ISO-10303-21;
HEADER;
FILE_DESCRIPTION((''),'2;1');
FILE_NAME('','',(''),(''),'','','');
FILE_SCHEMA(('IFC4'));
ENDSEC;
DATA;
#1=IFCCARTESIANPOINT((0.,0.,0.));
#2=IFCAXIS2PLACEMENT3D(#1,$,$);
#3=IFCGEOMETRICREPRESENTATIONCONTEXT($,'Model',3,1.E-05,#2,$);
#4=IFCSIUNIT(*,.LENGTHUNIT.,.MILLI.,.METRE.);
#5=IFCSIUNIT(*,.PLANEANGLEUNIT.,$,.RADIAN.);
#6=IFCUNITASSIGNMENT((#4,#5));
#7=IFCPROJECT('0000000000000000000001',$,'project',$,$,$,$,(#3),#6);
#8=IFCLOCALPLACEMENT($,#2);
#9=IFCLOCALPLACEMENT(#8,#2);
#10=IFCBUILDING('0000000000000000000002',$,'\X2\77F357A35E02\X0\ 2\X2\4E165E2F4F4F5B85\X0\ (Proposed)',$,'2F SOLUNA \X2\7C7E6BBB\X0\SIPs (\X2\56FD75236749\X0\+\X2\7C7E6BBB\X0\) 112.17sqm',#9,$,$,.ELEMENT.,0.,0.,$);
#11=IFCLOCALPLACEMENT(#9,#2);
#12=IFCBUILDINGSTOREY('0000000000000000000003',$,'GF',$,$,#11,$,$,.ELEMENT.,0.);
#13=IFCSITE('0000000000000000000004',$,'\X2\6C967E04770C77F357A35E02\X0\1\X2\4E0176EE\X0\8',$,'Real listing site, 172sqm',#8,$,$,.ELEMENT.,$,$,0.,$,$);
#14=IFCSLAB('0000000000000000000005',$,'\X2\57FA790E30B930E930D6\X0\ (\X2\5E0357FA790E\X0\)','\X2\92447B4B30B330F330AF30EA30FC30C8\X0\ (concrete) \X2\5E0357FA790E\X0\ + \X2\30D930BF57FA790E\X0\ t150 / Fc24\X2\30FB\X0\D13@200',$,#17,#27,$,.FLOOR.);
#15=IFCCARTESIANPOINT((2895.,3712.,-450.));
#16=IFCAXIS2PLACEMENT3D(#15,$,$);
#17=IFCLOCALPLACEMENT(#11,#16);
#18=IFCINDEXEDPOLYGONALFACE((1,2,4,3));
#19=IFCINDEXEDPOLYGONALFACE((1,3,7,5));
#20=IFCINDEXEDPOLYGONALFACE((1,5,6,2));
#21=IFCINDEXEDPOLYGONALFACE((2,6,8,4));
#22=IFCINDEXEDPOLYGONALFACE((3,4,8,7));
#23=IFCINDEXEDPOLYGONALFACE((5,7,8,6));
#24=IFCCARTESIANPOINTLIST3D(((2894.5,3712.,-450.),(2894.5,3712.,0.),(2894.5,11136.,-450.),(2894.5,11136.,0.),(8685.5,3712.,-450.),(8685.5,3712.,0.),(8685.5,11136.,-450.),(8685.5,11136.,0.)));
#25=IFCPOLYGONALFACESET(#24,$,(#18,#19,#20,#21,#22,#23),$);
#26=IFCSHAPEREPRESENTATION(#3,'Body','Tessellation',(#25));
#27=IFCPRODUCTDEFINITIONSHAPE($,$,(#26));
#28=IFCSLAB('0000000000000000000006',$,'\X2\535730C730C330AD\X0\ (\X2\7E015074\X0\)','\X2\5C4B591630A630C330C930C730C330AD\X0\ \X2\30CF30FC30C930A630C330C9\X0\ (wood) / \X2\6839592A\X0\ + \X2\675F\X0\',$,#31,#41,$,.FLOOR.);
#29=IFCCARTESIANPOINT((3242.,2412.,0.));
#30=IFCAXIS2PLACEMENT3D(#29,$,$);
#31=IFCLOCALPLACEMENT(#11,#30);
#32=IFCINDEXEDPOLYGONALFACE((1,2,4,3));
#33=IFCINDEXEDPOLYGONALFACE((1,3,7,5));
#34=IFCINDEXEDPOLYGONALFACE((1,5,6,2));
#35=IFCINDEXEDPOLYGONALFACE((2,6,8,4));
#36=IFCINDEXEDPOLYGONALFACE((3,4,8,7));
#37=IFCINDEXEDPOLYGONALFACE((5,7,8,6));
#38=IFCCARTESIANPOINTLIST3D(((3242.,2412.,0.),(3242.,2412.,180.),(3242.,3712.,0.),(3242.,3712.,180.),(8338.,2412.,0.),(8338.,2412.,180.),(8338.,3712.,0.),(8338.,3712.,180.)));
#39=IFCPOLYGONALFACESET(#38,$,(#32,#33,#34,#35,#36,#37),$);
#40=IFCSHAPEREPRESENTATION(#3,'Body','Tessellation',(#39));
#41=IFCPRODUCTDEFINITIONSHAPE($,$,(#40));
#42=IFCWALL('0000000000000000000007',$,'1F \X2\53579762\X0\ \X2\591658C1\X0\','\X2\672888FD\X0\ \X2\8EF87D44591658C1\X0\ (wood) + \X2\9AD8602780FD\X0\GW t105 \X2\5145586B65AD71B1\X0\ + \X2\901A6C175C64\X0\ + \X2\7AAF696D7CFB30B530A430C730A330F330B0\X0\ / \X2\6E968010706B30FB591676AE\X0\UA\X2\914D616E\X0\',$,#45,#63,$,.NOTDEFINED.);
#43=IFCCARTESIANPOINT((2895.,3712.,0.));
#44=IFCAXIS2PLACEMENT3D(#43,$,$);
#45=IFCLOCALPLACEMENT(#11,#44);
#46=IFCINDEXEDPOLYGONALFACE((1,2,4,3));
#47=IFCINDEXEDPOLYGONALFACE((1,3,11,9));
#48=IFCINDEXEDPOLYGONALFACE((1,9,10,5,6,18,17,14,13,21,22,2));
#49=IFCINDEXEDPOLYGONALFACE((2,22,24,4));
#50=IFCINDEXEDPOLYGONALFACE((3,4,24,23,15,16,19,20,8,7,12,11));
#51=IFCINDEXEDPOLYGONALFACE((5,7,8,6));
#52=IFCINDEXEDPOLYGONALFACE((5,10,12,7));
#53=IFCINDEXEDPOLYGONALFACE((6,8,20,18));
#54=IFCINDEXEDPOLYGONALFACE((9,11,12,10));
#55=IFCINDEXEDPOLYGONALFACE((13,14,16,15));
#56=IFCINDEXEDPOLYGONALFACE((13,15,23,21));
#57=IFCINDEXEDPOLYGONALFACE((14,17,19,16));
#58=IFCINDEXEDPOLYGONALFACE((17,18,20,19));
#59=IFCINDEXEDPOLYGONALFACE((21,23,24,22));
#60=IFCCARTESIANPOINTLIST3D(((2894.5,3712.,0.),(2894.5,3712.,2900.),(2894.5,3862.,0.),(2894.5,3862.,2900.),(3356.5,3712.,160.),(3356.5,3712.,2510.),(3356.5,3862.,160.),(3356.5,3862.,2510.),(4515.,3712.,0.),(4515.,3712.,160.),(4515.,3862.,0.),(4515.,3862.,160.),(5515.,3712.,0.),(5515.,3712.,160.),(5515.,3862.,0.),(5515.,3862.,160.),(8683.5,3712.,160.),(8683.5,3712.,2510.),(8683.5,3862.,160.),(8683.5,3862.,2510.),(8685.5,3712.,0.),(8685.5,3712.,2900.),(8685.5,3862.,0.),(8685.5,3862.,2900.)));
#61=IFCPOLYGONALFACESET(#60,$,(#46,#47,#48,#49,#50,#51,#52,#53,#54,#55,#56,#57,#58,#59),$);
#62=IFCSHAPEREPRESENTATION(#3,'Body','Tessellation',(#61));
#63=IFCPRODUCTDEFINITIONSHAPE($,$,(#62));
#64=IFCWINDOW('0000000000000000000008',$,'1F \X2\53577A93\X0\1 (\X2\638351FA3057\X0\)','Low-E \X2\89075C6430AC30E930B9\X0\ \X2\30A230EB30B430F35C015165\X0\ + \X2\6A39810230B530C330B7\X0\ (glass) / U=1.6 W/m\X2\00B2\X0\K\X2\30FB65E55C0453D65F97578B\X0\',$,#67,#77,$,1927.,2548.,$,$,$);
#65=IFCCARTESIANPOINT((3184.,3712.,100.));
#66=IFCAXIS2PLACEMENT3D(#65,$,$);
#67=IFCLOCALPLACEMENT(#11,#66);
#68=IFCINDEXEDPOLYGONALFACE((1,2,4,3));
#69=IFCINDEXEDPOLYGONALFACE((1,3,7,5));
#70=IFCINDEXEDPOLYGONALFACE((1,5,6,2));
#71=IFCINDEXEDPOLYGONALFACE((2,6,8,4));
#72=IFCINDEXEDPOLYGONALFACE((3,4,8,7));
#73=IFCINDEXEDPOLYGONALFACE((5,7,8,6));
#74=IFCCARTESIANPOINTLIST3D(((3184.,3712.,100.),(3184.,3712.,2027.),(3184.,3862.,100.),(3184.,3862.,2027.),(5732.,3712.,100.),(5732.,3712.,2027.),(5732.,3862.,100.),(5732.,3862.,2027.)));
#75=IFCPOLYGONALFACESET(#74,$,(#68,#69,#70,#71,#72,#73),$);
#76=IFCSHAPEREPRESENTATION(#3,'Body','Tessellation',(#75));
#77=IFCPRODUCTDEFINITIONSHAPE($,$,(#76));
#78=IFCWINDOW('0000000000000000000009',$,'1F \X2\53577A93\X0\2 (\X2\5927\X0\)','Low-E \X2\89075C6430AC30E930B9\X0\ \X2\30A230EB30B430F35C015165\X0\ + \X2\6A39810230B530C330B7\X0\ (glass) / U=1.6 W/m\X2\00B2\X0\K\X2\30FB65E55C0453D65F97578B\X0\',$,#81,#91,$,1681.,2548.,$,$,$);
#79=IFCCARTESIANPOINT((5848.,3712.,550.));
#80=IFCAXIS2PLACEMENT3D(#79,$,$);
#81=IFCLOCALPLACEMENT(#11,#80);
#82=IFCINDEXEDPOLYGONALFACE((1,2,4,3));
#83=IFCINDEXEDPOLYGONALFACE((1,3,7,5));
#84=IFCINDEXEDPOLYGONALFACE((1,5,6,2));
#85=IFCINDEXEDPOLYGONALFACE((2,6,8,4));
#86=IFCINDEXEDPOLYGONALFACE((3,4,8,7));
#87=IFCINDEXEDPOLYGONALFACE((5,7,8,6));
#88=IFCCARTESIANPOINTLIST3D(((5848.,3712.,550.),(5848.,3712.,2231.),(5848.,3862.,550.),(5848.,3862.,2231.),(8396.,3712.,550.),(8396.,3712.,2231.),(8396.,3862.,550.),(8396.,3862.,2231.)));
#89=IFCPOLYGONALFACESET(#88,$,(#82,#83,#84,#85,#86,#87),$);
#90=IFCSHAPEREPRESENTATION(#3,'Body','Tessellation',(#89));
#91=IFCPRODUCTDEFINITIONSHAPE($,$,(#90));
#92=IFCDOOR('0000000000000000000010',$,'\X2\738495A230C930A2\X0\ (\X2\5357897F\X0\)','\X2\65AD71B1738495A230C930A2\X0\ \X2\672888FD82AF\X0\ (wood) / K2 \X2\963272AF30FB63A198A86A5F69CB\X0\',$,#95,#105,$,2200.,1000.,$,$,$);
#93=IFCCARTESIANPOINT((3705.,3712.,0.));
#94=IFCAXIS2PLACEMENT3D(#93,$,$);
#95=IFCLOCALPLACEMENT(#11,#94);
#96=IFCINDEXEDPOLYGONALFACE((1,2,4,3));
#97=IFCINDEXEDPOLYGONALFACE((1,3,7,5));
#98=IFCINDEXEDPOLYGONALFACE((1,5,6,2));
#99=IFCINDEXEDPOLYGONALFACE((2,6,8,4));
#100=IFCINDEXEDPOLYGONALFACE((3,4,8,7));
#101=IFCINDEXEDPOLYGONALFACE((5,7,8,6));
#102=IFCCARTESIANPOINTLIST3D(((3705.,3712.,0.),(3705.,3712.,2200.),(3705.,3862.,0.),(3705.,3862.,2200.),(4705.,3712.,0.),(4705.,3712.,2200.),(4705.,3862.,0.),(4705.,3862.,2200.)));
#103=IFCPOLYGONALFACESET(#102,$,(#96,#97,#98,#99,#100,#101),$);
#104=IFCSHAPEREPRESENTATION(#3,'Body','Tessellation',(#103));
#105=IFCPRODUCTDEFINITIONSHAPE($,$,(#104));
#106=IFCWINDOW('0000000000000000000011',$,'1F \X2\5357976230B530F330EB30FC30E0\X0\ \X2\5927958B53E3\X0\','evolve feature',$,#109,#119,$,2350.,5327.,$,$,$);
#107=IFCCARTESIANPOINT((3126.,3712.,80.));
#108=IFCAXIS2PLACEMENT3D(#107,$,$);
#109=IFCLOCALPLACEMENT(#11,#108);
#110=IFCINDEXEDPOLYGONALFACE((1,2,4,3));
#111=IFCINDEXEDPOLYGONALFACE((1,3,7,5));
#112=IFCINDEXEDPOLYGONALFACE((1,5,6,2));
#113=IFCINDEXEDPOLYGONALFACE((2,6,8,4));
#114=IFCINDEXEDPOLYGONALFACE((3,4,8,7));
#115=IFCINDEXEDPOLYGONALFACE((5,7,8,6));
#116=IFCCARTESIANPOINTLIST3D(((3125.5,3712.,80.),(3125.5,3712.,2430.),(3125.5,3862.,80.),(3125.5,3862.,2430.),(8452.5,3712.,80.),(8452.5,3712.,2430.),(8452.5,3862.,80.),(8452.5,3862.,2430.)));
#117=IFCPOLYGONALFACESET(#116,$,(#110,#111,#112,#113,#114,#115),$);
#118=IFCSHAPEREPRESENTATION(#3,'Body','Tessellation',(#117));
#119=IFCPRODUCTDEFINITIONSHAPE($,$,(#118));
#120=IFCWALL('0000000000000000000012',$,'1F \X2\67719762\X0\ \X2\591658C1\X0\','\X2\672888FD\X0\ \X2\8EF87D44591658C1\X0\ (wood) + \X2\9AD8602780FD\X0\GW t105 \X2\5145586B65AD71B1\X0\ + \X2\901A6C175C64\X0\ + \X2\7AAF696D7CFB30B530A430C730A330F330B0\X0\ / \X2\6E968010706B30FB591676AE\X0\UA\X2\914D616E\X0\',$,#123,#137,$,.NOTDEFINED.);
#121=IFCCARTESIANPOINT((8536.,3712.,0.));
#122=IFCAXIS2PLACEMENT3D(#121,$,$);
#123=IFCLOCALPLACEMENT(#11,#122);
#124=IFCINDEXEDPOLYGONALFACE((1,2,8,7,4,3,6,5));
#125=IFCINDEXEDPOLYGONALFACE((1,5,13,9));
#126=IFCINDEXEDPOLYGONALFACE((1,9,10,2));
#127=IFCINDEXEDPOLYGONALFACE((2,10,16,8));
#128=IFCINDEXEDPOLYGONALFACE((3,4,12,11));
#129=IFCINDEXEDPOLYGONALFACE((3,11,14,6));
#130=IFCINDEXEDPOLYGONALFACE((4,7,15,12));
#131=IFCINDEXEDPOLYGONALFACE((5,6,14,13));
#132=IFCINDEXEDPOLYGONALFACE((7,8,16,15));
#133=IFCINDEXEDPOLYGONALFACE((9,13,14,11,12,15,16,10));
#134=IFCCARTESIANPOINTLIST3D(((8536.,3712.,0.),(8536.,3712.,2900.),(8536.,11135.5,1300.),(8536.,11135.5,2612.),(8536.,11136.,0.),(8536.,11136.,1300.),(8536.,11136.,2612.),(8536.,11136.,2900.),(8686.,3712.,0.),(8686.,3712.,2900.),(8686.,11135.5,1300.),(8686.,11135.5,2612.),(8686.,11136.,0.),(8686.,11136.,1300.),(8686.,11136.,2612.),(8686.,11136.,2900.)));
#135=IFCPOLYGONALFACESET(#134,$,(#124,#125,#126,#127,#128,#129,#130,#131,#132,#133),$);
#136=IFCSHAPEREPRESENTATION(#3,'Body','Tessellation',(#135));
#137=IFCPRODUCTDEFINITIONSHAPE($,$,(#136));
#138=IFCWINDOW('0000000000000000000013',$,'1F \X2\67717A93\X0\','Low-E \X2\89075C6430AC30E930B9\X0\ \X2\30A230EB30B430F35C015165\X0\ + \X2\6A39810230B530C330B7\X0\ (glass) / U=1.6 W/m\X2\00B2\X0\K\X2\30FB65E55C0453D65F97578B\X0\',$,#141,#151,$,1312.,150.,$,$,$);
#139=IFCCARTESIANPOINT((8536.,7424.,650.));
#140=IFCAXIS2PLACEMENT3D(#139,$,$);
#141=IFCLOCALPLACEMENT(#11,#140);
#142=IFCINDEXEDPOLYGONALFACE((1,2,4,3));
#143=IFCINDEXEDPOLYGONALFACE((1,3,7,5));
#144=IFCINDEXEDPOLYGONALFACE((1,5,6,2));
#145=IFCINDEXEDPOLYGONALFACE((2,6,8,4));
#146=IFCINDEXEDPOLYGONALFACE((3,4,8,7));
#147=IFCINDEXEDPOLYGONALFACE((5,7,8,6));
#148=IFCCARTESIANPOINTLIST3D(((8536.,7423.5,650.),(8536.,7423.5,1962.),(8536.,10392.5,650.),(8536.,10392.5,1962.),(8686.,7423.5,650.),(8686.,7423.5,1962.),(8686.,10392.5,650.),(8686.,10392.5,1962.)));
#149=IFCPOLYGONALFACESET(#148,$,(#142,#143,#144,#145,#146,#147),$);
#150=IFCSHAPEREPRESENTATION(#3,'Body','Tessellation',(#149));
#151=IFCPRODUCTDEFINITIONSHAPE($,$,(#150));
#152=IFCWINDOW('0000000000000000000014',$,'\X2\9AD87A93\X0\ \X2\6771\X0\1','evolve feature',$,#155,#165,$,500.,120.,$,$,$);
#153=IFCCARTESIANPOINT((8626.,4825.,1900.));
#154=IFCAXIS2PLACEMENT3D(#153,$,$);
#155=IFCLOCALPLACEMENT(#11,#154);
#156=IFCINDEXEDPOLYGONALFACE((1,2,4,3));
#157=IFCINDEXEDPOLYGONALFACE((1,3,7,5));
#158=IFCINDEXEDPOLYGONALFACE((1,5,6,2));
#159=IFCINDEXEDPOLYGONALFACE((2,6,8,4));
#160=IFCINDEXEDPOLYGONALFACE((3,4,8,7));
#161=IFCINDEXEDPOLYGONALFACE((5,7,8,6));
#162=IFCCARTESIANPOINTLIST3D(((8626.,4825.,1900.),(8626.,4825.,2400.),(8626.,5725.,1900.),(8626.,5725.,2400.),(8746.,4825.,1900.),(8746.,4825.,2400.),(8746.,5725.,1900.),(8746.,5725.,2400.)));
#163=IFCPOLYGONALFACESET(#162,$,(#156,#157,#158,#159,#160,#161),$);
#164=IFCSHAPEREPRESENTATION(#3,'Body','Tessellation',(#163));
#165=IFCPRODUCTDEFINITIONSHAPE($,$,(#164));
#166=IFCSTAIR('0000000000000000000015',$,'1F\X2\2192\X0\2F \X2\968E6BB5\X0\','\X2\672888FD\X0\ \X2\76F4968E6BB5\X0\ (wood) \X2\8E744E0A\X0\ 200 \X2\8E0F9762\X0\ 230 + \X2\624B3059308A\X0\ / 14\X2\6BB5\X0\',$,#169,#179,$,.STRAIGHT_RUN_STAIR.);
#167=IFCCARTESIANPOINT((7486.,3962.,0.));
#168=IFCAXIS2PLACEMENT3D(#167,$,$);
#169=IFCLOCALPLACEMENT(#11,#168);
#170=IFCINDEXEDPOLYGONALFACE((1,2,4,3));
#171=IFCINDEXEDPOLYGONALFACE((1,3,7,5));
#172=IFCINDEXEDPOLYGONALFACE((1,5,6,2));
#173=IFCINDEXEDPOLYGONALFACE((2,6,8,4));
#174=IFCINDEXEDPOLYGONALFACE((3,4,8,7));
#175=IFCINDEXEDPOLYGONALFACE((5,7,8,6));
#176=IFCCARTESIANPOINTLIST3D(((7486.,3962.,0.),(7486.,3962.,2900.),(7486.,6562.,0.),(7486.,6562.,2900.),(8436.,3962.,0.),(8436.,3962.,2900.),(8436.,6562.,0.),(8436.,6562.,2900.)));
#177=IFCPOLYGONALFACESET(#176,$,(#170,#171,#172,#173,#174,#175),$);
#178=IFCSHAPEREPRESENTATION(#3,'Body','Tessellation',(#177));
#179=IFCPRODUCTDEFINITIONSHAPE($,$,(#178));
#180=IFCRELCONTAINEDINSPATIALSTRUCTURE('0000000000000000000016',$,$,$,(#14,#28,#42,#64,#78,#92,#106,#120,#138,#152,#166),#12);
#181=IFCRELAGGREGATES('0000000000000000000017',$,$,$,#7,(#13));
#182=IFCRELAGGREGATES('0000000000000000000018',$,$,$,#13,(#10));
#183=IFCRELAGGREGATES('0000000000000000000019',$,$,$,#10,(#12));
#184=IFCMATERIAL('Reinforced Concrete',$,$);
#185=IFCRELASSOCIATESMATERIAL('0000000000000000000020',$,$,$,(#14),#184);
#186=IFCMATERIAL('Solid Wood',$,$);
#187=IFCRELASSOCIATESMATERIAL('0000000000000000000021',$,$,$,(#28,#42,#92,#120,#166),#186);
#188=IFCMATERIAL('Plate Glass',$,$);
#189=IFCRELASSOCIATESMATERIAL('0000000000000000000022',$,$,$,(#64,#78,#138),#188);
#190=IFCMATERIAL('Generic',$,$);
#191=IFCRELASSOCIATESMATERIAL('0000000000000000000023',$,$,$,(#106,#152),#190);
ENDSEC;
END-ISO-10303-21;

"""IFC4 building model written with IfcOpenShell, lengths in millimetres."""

from ifc_helpers import new_model, si_unit, frame, frame_2d, origin, place, context, project, spatial, rectangle, extrude, material, element, fill, save


model = new_model("IFC4")

# Units and contexts
model_context = context("Model", 3, precision=1e-05, world=origin())
ifc_project = project(units=[si_unit("LENGTHUNIT", "METRE", prefix="MILLI"), si_unit("PLANEANGLEUNIT", "RADIAN")], contexts=[model_context])

# Site, building, storey
site_placement = place(None, origin())
site = spatial("IfcSite", under=ifc_project, at=site_placement, Name="沖縄県石垣市1丁目8", ObjectType="Real listing site, 172sqm", CompositionType="ELEMENT", RefElevation=0.0)
building_placement = place(site_placement, origin())
building = spatial("IfcBuilding", under=site, at=building_placement, Name="石垣市 2世帯住宅 (Proposed)", ObjectType="2F SOLUNA 籾殻SIPs (国産杉+籾殻) 112.17sqm", CompositionType="ELEMENT", ElevationOfRefHeight=0.0, ElevationOfTerrain=0.0)
storey_placement = place(building_placement, origin())
storey = spatial("IfcBuildingStorey", under=building, at=storey_placement, Name="GF", CompositionType="ELEMENT", Elevation=0.0)

# Slabs
ifc_material_1 = material(Name="Reinforced Concrete")
slab_1_placement = place(storey_placement, frame((2895.0, 3712.0, -450.0)))
element("IfcSlab", 1, at=slab_1_placement, inside=storey, material=ifc_material_1, Name="基礎スラブ (布基礎)", Description="鉄筋コンクリート (concrete) 布基礎 + ベタ基礎 t150 / Fc24・D13@200", PredefinedType="FLOOR", context=model_context, shape_type="SweptSolid", body=[
    extrude(rectangle(XDim=5791.0, YDim=7424.0, at=frame_2d((2895.0, 3712.0))), frame((2895.0, 3712.0, -450.0)), (0.0, 0.0, 1.0), 450.0),
])
ifc_material_2 = material(Name="Solid Wood")
slab_2_placement = place(storey_placement, frame((3242.0, 2412.0, 0.0)))
element("IfcSlab", 2, at=slab_2_placement, inside=storey, material=ifc_material_2, Name="南デッキ (縁側)", Description="屋外ウッドデッキ ハードウッド (wood) / 根太 + 束", PredefinedType="FLOOR", context=model_context, shape_type="SweptSolid", body=[
    extrude(rectangle(XDim=5096.0, YDim=1300.0, at=frame_2d((2548.0, 650.0))), frame((3242.0, 2412.0, 0.0)), (0.0, 0.0, 1.0), 180.0),
])
ifc_material_3 = material(Name="Generic")

# Wall, openings, windows, door
wall_1_placement = place(storey_placement, frame((2895.0, 3712.0, 0.0)))
wall_1 = element("IfcWall", 3, at=wall_1_placement, inside=storey, material=ifc_material_2, Name="1F 南面 外壁", Description="木製 軸組外壁 (wood) + 高性能GW t105 充填断熱 + 通気層 + 窯業系サイディング / 準耐火・外皮UA配慮", PredefinedType="NOTDEFINED", context=model_context, shape_type="SweptSolid", body=[
    extrude(rectangle(XDim=5791.0, YDim=150.0, at=frame_2d((2895.0, 75.0))), frame((2895.0, 3712.0, 0.0)), (0.0, 0.0, 1.0), 2900.0),
])
opening_1_placement = place(storey_placement, frame((3184.0, 3712.0, 100.0)))
opening_1 = element("IfcOpeningElement", 4, at=opening_1_placement, cuts=wall_1, PredefinedType="NOTDEFINED", context=model_context, shape_type="SweptSolid", body=[
    extrude(rectangle(XDim=2548.0, YDim=150.0, at=frame_2d((1274.0, 75.0))), frame((3184.0, 3712.0, 100.0)), (0.0, 0.0, 1.0), 1927.0),
])
opening_2_placement = place(storey_placement, frame((5848.0, 3712.0, 550.0)))
opening_2 = element("IfcOpeningElement", 5, at=opening_2_placement, cuts=wall_1, PredefinedType="NOTDEFINED", context=model_context, shape_type="SweptSolid", body=[
    extrude(rectangle(XDim=2548.0, YDim=150.0, at=frame_2d((1274.0, 75.0))), frame((5848.0, 3712.0, 550.0)), (0.0, 0.0, 1.0), 1681.0),
])
opening_3_placement = place(storey_placement, frame((3705.0, 3712.0, 0.0)))
opening_3 = element("IfcOpeningElement", 6, at=opening_3_placement, cuts=wall_1, PredefinedType="NOTDEFINED", context=model_context, shape_type="SweptSolid", body=[
    extrude(rectangle(XDim=1000.0, YDim=150.0, at=frame_2d((500.0, 75.0))), frame((3705.0, 3712.0, 0.0)), (0.0, 0.0, 1.0), 2200.0),
])
opening_4_placement = place(storey_placement, frame((3126.0, 3712.0, 80.0)))
opening_4 = element("IfcOpeningElement", 7, at=opening_4_placement, cuts=wall_1, PredefinedType="NOTDEFINED", context=model_context, shape_type="SweptSolid", body=[
    extrude(rectangle(XDim=5327.0, YDim=150.0, at=frame_2d((2663.0, 75.0))), frame((3126.0, 3712.0, 80.0)), (0.0, 0.0, 1.0), 2350.0),
])
ifc_material_4 = material(Name="Plate Glass")
window_1_placement = place(storey_placement, frame((3184.0, 3712.0, 100.0)))
window_1 = element("IfcWindow", 8, at=window_1_placement, inside=storey, material=ifc_material_4, Name="1F 南窓1 (掃出し)", Description="Low-E 複層ガラス アルゴン封入 + 樹脂サッシ (glass) / U=1.6 W/m²K・日射取得型", OverallHeight=1927.0, OverallWidth=2548.0, context=model_context, shape_type="SweptSolid", body=[
    extrude(rectangle(XDim=2548.0, YDim=150.0, at=frame_2d((1274.0, 75.0))), frame((3184.0, 3712.0, 100.0)), (0.0, 0.0, 1.0), 1927.0),
])
fill(opening_1, window_1)
window_2_placement = place(storey_placement, frame((5848.0, 3712.0, 550.0)))
window_2 = element("IfcWindow", 9, at=window_2_placement, inside=storey, material=ifc_material_4, Name="1F 南窓2 (大)", Description="Low-E 複層ガラス アルゴン封入 + 樹脂サッシ (glass) / U=1.6 W/m²K・日射取得型", OverallHeight=1681.0, OverallWidth=2548.0, context=model_context, shape_type="SweptSolid", body=[
    extrude(rectangle(XDim=2548.0, YDim=150.0, at=frame_2d((1274.0, 75.0))), frame((5848.0, 3712.0, 550.0)), (0.0, 0.0, 1.0), 1681.0),
])
fill(opening_2, window_2)
door_placement = place(storey_placement, frame((3705.0, 3712.0, 0.0)))
door = element("IfcDoor", 10, at=door_placement, inside=storey, material=ifc_material_2, Name="玄関ドア (南西)", Description="断熱玄関ドア 木製芯 (wood) / K2 防犯・採風機構", OverallHeight=2200.0, OverallWidth=1000.0, context=model_context, shape_type="SweptSolid", body=[
    extrude(rectangle(XDim=1000.0, YDim=150.0, at=frame_2d((500.0, 75.0))), frame((3705.0, 3712.0, 0.0)), (0.0, 0.0, 1.0), 2200.0),
])
fill(opening_3, door)
window_3_placement = place(storey_placement, frame((3126.0, 3712.0, 80.0)))
window_3 = element("IfcWindow", 11, at=window_3_placement, inside=storey, material=ifc_material_3, Name="1F 南面サンルーム 大開口", Description="evolve feature", OverallHeight=2350.0, OverallWidth=5327.0, context=model_context, shape_type="SweptSolid", body=[
    extrude(rectangle(XDim=5327.0, YDim=150.0, at=frame_2d((2663.0, 75.0))), frame((3126.0, 3712.0, 80.0)), (0.0, 0.0, 1.0), 2350.0),
])
fill(opening_4, window_3)

# Wall, openings, windows
wall_2_placement = place(storey_placement, frame((8536.0, 3712.0, 0.0)))
wall_2 = element("IfcWall", 12, at=wall_2_placement, inside=storey, material=ifc_material_2, Name="1F 東面 外壁", Description="木製 軸組外壁 (wood) + 高性能GW t105 充填断熱 + 通気層 + 窯業系サイディング / 準耐火・外皮UA配慮", PredefinedType="NOTDEFINED", context=model_context, shape_type="SweptSolid", body=[
    extrude(rectangle(XDim=150.0, YDim=7424.0, at=frame_2d((75.0, 3712.0))), frame((8536.0, 3712.0, 0.0)), (0.0, 0.0, 1.0), 2900.0),
])
opening_5_placement = place(storey_placement, frame((8536.0, 7424.0, 650.0)))
opening_5 = element("IfcOpeningElement", 13, at=opening_5_placement, cuts=wall_2, PredefinedType="NOTDEFINED", context=model_context, shape_type="SweptSolid", body=[
    extrude(rectangle(XDim=150.0, YDim=2969.0, at=frame_2d((75.0, 1484.0))), frame((8536.0, 7424.0, 650.0)), (0.0, 0.0, 1.0), 1312.0),
])
opening_6_placement = place(storey_placement, frame((8626.0, 4825.0, 1900.0)))
opening_6 = element("IfcOpeningElement", 14, at=opening_6_placement, cuts=wall_2, PredefinedType="NOTDEFINED", context=model_context, shape_type="SweptSolid", body=[
    extrude(rectangle(XDim=120.0, YDim=900.0, at=frame_2d((60.0, 450.0))), frame((8626.0, 4825.0, 1900.0)), (0.0, 0.0, 1.0), 500.0),
])
window_4_placement = place(storey_placement, frame((8536.0, 7424.0, 650.0)))
window_4 = element("IfcWindow", 15, at=window_4_placement, inside=storey, material=ifc_material_4, Name="1F 東窓", Description="Low-E 複層ガラス アルゴン封入 + 樹脂サッシ (glass) / U=1.6 W/m²K・日射取得型", OverallHeight=1312.0, OverallWidth=150.0, context=model_context, shape_type="SweptSolid", body=[
    extrude(rectangle(XDim=150.0, YDim=2969.0, at=frame_2d((75.0, 1484.0))), frame((8536.0, 7424.0, 650.0)), (0.0, 0.0, 1.0), 1312.0),
])
fill(opening_5, window_4)
window_5_placement = place(storey_placement, frame((8626.0, 4825.0, 1900.0)))
window_5 = element("IfcWindow", 16, at=window_5_placement, inside=storey, material=ifc_material_3, Name="高窓 東1", Description="evolve feature", OverallHeight=500.0, OverallWidth=120.0, context=model_context, shape_type="SweptSolid", body=[
    extrude(rectangle(XDim=120.0, YDim=900.0, at=frame_2d((60.0, 450.0))), frame((8626.0, 4825.0, 1900.0)), (0.0, 0.0, 1.0), 500.0),
])
fill(opening_6, window_5)

# Stair
stair_placement = place(storey_placement, frame((7486.0, 3962.0, 0.0)))
element("IfcStair", 17, at=stair_placement, inside=storey, material=ifc_material_2, Name="1F→2F 階段", Description="木製 直階段 (wood) 蹴上 200 踏面 230 + 手すり / 14段", PredefinedType="STRAIGHT_RUN_STAIR", context=model_context, shape_type="SweptSolid", body=[
    extrude(rectangle(XDim=950.0, YDim=2600.0, at=frame_2d((475.0, 1300.0))), frame((7486.0, 3962.0, 0.0)), (0.0, 0.0, 1.0), 2900.0),
])

save(model, "model.ifc")
